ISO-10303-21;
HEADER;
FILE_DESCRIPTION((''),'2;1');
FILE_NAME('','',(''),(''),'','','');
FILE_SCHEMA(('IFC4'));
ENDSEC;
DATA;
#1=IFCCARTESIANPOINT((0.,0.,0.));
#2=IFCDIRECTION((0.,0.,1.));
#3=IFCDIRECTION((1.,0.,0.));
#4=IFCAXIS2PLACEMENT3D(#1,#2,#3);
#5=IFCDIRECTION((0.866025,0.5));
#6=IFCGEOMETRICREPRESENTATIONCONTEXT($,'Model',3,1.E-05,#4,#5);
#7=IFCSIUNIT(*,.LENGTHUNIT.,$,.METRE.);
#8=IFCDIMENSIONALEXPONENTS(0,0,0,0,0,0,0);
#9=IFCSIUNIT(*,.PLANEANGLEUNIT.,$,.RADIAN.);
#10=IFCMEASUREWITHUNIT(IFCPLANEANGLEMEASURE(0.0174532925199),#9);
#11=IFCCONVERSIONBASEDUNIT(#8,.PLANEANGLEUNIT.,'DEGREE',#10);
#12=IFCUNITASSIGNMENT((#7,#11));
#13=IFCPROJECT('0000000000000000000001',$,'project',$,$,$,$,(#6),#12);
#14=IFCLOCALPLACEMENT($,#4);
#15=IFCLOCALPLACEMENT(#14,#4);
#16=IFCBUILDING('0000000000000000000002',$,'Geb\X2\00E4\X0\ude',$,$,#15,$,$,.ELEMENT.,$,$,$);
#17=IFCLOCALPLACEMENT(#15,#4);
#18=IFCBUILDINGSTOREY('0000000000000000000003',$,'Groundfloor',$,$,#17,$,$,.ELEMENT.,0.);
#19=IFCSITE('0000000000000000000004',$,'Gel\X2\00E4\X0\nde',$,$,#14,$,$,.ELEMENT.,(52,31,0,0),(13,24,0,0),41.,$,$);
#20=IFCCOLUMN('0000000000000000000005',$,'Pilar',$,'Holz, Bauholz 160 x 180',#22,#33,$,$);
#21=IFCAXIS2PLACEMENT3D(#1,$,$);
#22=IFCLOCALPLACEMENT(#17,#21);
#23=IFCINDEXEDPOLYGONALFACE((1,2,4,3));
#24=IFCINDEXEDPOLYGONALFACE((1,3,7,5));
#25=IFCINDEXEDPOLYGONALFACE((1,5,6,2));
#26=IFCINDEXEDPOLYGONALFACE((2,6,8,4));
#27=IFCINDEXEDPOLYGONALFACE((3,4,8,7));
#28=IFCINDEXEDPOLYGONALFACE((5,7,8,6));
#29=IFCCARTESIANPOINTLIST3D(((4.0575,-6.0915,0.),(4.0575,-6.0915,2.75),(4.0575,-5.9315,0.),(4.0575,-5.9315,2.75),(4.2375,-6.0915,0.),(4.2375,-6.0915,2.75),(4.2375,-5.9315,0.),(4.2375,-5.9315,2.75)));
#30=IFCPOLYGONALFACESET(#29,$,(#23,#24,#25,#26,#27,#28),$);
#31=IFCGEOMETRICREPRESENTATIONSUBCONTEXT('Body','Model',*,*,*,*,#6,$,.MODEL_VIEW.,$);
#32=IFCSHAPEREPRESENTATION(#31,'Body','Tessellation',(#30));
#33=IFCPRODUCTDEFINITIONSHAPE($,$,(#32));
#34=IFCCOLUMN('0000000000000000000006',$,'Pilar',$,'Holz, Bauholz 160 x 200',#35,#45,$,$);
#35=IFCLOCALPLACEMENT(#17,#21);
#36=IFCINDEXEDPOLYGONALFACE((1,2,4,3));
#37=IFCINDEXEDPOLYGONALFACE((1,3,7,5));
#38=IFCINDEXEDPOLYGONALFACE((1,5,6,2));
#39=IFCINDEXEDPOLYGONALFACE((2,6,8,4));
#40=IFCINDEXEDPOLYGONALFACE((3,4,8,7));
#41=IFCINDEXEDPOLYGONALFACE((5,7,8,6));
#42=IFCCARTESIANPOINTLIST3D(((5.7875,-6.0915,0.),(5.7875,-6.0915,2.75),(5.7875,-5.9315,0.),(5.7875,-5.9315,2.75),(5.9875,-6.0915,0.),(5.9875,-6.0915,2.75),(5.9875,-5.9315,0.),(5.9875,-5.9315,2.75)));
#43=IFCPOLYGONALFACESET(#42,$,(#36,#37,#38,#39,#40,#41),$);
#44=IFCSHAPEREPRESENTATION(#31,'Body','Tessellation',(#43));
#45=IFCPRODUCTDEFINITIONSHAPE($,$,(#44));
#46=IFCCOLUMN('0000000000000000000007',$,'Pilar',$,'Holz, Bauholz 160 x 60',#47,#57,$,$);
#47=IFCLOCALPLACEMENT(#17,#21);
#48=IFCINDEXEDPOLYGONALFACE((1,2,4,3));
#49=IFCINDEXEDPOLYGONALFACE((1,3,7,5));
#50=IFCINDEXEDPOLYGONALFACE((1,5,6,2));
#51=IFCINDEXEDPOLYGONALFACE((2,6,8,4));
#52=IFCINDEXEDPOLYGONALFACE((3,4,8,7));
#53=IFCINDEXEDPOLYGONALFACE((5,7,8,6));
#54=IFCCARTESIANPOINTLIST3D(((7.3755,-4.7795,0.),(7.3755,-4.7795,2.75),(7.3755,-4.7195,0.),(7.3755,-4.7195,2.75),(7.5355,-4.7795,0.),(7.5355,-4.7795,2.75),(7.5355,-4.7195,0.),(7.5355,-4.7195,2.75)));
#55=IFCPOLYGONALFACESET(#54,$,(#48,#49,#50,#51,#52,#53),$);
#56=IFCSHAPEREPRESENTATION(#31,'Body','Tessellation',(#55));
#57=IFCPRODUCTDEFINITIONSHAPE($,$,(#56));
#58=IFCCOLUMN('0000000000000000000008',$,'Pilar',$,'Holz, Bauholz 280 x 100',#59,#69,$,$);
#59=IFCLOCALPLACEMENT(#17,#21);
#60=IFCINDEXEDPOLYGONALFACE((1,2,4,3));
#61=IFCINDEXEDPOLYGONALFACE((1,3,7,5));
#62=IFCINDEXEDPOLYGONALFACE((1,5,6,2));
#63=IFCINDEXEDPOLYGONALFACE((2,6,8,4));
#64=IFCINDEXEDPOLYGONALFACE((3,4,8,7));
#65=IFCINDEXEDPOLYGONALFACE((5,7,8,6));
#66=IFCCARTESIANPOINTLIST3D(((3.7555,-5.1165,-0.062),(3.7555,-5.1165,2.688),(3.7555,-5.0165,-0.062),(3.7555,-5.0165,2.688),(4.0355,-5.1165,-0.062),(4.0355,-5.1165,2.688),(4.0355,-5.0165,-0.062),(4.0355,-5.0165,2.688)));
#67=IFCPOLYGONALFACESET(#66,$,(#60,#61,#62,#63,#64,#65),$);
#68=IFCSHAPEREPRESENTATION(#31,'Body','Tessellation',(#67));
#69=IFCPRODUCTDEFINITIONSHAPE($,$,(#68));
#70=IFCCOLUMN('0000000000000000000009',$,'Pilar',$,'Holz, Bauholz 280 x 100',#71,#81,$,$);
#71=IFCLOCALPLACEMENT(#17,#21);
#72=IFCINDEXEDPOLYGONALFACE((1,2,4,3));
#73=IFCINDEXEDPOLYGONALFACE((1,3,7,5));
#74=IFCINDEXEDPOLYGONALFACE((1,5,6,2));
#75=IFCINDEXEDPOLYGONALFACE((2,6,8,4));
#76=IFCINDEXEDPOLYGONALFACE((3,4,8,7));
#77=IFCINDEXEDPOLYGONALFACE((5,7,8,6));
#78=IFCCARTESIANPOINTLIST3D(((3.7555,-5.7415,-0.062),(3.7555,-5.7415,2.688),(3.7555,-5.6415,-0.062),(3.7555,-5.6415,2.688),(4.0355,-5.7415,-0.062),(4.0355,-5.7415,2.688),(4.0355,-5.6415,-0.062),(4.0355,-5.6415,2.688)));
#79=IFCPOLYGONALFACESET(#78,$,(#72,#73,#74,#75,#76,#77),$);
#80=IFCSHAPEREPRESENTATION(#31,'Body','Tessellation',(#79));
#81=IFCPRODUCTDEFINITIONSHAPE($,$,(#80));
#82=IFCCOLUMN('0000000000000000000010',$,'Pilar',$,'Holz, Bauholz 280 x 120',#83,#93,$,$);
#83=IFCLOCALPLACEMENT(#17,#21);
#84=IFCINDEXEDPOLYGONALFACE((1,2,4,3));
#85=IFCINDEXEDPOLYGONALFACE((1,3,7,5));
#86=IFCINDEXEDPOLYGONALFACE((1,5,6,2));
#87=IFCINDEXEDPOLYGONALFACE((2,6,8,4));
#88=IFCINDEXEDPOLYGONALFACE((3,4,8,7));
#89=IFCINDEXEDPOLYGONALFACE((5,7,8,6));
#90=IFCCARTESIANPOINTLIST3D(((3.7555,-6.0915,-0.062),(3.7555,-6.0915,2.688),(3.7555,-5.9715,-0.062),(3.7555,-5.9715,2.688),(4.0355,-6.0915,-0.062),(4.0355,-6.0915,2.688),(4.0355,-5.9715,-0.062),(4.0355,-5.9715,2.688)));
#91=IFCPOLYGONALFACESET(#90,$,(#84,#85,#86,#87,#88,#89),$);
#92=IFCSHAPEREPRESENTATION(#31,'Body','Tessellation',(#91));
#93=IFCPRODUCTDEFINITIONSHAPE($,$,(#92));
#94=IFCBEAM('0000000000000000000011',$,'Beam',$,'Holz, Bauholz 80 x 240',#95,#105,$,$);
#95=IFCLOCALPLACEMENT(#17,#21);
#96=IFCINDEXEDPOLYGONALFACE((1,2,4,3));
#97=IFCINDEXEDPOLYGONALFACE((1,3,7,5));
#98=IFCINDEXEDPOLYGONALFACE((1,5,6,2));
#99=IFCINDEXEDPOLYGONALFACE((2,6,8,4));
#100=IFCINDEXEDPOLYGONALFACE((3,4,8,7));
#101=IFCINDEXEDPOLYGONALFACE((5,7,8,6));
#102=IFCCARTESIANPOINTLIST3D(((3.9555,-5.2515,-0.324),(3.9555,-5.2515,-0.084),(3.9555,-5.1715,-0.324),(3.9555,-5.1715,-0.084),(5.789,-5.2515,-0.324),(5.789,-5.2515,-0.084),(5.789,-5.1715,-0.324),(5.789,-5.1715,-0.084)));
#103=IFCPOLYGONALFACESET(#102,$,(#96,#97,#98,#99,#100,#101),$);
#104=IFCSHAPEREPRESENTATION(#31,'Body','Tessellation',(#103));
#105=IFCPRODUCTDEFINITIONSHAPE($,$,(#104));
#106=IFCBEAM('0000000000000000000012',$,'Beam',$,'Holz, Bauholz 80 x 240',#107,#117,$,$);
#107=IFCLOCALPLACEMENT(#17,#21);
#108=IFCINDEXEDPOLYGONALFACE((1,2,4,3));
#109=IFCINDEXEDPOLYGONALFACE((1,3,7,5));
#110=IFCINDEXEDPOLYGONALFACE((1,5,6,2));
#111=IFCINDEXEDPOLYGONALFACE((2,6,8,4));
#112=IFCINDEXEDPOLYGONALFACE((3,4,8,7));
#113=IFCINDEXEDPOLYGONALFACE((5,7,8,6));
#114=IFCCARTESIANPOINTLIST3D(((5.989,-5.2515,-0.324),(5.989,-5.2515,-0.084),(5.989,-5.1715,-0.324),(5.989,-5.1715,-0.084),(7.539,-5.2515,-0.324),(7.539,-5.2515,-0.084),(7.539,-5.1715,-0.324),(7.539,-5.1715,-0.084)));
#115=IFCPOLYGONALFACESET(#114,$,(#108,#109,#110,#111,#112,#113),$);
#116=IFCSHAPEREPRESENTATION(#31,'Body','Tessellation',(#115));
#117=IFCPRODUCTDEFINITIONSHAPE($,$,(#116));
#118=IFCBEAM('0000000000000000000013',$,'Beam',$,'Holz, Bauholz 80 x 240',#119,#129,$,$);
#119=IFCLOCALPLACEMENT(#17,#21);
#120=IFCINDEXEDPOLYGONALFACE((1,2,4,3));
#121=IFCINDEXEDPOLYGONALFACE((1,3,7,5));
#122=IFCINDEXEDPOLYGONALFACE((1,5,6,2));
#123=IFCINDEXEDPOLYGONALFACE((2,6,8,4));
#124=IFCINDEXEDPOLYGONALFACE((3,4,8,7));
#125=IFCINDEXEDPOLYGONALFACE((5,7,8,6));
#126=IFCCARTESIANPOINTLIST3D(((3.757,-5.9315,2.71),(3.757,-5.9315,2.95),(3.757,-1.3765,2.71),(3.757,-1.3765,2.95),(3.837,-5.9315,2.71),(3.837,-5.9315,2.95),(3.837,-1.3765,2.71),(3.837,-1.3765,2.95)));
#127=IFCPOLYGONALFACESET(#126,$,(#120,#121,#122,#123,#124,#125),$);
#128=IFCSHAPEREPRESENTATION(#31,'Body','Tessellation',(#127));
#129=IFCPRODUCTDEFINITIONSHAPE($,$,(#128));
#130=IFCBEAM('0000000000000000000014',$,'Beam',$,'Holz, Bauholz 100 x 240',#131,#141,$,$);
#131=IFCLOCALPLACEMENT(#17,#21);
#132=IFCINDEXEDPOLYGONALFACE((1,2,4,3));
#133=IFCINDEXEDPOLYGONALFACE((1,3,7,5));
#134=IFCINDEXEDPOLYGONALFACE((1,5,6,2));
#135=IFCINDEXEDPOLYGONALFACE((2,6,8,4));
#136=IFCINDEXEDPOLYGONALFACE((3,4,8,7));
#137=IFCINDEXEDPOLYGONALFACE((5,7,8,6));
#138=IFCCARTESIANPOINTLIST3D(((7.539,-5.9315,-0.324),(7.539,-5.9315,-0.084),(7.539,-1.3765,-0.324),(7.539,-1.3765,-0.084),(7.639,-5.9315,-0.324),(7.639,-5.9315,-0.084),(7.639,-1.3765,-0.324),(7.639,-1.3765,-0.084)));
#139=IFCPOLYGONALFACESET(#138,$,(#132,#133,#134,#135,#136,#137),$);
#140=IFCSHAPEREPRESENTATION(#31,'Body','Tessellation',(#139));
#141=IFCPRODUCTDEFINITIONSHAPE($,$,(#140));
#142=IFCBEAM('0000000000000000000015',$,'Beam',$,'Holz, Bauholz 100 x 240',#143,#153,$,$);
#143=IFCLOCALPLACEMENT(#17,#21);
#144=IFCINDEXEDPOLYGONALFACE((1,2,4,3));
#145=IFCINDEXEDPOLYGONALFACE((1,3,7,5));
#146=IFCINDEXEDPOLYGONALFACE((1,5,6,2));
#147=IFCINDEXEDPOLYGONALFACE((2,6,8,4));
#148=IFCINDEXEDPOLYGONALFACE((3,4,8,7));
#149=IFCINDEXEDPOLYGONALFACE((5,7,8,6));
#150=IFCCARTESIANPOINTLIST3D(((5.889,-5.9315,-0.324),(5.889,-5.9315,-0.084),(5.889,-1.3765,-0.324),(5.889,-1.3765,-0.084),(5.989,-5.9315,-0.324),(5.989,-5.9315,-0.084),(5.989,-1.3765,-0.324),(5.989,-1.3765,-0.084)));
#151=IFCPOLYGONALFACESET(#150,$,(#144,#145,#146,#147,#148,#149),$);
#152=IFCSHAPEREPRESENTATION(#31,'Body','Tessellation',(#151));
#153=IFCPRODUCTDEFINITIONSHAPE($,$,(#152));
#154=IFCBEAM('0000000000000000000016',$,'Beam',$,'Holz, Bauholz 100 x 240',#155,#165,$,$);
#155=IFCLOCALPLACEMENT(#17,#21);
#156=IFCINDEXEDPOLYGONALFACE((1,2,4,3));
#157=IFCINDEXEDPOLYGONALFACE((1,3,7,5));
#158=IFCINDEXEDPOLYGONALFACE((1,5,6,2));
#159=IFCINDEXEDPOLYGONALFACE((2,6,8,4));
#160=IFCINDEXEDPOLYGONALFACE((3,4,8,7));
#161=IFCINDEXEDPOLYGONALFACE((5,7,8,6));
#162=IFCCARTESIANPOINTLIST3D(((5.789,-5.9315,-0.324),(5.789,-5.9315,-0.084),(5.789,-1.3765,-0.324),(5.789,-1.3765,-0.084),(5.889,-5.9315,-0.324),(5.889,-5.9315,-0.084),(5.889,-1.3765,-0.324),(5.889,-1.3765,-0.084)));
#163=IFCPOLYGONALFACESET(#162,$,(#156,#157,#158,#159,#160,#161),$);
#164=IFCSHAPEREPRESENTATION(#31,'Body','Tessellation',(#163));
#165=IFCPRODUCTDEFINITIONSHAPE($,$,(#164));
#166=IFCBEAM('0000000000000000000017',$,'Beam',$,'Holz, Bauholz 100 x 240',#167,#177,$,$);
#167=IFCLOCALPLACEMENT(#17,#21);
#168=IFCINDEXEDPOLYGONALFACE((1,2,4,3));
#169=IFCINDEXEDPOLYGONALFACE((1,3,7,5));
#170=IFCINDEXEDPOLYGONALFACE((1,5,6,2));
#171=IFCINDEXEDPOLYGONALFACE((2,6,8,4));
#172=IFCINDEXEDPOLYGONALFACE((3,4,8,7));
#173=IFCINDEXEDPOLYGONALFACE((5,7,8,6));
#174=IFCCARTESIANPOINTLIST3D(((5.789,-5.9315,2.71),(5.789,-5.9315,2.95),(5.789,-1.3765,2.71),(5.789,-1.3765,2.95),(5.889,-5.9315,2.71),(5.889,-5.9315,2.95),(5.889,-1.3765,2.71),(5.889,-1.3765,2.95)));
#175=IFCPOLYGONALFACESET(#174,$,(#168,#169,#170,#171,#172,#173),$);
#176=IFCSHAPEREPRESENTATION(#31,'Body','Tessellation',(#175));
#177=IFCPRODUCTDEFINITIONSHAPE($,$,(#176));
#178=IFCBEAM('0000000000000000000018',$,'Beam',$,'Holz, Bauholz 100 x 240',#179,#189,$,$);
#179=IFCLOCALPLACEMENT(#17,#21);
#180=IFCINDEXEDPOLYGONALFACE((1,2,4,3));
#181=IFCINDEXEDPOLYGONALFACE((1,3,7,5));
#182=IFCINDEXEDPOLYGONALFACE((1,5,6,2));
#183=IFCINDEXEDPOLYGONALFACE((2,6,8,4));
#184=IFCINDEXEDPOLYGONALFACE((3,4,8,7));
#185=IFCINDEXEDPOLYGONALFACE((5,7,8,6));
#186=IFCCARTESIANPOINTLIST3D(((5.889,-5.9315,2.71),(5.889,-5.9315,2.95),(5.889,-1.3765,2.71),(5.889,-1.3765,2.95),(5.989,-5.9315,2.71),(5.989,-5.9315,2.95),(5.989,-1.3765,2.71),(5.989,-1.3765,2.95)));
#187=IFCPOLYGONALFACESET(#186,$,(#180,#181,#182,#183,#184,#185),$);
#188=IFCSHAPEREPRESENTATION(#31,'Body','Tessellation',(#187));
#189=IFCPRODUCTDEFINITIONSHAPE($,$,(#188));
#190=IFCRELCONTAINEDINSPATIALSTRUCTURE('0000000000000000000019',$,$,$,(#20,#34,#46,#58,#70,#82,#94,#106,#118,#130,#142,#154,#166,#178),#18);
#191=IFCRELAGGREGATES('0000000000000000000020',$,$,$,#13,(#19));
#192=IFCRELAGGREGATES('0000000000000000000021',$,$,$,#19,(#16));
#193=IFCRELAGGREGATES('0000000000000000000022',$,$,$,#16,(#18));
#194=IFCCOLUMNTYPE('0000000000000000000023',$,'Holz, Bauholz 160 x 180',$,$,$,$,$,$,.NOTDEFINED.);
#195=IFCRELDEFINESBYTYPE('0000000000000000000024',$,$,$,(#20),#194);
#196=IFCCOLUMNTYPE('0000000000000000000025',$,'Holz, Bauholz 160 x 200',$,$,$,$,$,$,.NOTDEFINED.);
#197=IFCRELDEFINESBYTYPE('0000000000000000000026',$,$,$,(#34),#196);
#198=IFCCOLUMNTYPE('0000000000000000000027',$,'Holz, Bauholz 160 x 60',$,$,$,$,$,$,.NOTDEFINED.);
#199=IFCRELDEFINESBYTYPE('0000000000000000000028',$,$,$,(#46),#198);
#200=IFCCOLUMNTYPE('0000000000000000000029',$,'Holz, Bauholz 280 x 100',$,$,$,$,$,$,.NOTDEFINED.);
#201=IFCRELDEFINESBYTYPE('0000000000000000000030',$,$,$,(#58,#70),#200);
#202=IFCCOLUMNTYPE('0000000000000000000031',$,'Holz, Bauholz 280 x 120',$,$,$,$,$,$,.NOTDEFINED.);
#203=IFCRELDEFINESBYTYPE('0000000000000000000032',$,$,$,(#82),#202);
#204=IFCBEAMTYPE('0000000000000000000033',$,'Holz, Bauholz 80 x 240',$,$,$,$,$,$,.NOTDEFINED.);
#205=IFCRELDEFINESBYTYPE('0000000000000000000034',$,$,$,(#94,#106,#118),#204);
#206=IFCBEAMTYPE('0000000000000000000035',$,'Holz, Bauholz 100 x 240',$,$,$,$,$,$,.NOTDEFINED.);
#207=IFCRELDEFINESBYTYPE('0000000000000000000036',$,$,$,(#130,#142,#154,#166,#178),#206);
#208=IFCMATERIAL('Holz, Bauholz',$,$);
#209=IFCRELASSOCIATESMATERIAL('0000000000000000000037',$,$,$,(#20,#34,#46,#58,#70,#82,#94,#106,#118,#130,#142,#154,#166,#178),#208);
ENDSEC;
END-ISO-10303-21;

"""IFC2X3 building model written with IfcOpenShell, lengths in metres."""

from ifc_helpers import new_model, entity, si_unit, converted_unit, direction, frame, frame_2d, origin_with_axes, origin_2d_with_axis, place, context, subcontext, project, spatial, rectangle, extrude, clip, halfspace, material, type_object, element, save


model = new_model("IFC2X3")

# Units and contexts
model_context = context("Model", 3, precision=1e-05, world=origin_with_axes(), true_north=direction((0.866025, 0.5)))
body_context = subcontext(model_context, "Body", "Model", "MODEL_VIEW")
ifc_project = project(units=[si_unit("LENGTHUNIT", "METRE"), converted_unit("PLANEANGLEUNIT", "DEGREE", entity("IfcPlaneAngleMeasure", 0.0174532925199), si_unit("PLANEANGLEUNIT", "RADIAN"), dimensions=[0, 0, 0, 0, 0, 0, 0])], contexts=[model_context])

# Site, building, storey
site_placement = place(None, origin_with_axes())
site = spatial("IfcSite", under=ifc_project, at=site_placement, Name="Gelände", CompositionType="ELEMENT", RefLatitude=(52, 31, 0, 0), RefLongitude=(13, 24, 0, 0), RefElevation=41.0)
building_placement = place(site_placement, origin_with_axes())
building = spatial("IfcBuilding", under=site, at=building_placement, Name="Gebäude", CompositionType="ELEMENT")
storey_placement = place(building_placement, origin_with_axes())
storey = spatial("IfcBuildingStorey", under=building, at=storey_placement, Name="Groundfloor", CompositionType="ELEMENT", Elevation=0.0)

# Columns
ifc_material_1 = material(Name="Holz, Bauholz")
column_type_1 = type_object("IfcColumnType", Name="Holz, Bauholz 160 x 180", PredefinedType="NOTDEFINED")
column_1_placement = place(storey_placement, frame((4.1475, -6.0115, 0.0), z_axis=(0.0, 0.0, 1.0), x_axis=(1.0, 0.0, 0.0)))
element("IfcColumn", 1, at=column_1_placement, inside=storey, type_object=column_type_1, material=ifc_material_1, Name="Pilar", ObjectType="Holz, Bauholz 160 x 180", context=body_context, shape_type="Clipping", body=[
    clip(clip(extrude(rectangle(XDim=0.16, YDim=0.18, at=origin_2d_with_axis()), frame((0.0, 0.0, 0.0), z_axis=(0.0, 0.0, 1.0), x_axis=(0.0, 1.0, 0.0)), (0.0, 0.0, 1.0), 2.75), halfspace(frame((0.0, 0.0, 2.75), z_axis=(0.0, 0.0, -1.0), x_axis=(0.0, 1.0, 0.0)), True)), halfspace(frame((0.0, 0.0, 0.0), z_axis=(0.0, 0.0, 1.0), x_axis=(0.0, -1.0, 0.0)), True)),
])
column_type_2 = type_object("IfcColumnType", Name="Holz, Bauholz 160 x 200", PredefinedType="NOTDEFINED")
column_2_placement = place(storey_placement, frame((5.8875, -6.0115, 0.0), z_axis=(0.0, 0.0, 1.0), x_axis=(1.0, 0.0, 0.0)))
element("IfcColumn", 2, at=column_2_placement, inside=storey, type_object=column_type_2, material=ifc_material_1, Name="Pilar", ObjectType="Holz, Bauholz 160 x 200", context=body_context, shape_type="Clipping", body=[
    clip(clip(extrude(rectangle(XDim=0.16, YDim=0.2, at=origin_2d_with_axis()), frame((0.0, 0.0, 0.0), z_axis=(0.0, 0.0, 1.0), x_axis=(0.0, 1.0, 0.0)), (0.0, 0.0, 1.0), 2.75), halfspace(frame((0.0, 0.0, 2.75), z_axis=(0.0, 0.0, -1.0), x_axis=(0.0, 1.0, 0.0)), True)), halfspace(frame((0.0, 0.0, 0.0), z_axis=(0.0, 0.0, 1.0), x_axis=(0.0, -1.0, 0.0)), True)),
])
column_type_3 = type_object("IfcColumnType", Name="Holz, Bauholz 160 x 60", PredefinedType="NOTDEFINED")
column_3_placement = place(storey_placement, frame((7.4555, -4.7495, 0.0), z_axis=(0.0, 0.0, 1.0), x_axis=(0.0, -1.0, 0.0)))
element("IfcColumn", 3, at=column_3_placement, inside=storey, type_object=column_type_3, material=ifc_material_1, Name="Pilar", ObjectType="Holz, Bauholz 160 x 60", context=body_context, shape_type="Clipping", body=[
    clip(clip(extrude(rectangle(XDim=0.16, YDim=0.06, at=origin_2d_with_axis()), frame((0.0, 0.0, 0.0), z_axis=(0.0, 0.0, 1.0), x_axis=(0.0, 1.0, 0.0)), (0.0, 0.0, 1.0), 2.75), halfspace(frame((0.0, 0.0, 2.75), z_axis=(0.0, 0.0, -1.0), x_axis=(0.0, 1.0, 0.0)), True)), halfspace(frame((0.0, 0.0, 0.0), z_axis=(0.0, 0.0, 1.0), x_axis=(0.0, -1.0, 0.0)), True)),
])
column_type_4 = type_object("IfcColumnType", Name="Holz, Bauholz 280 x 100", PredefinedType="NOTDEFINED")
for number, where, z_axis, x_axis, name in (
    (4, (3.8955, -5.0665, -0.062), (0.0, 0.0, 1.0), (0.0, 1.0, 0.0), "Pilar"),
    (5, (3.8955, -5.6915, -0.062), (0.0, 0.0, 1.0), (0.0, 1.0, 0.0), "Pilar"),
):
    element("IfcColumn", number, at=place(storey_placement, frame(where, z_axis=z_axis, x_axis=x_axis)), inside=storey, type_object=column_type_4, material=ifc_material_1, Name=name, ObjectType="Holz, Bauholz 280 x 100", context=body_context, shape_type="Clipping", body=[
        clip(clip(extrude(rectangle(XDim=0.28, YDim=0.1, at=origin_2d_with_axis()), frame((0.0, 0.0, 0.0), z_axis=(0.0, 0.0, 1.0), x_axis=(0.0, 1.0, 0.0)), (0.0, 0.0, 1.0), 2.75), halfspace(frame((0.0, 0.0, 2.75), z_axis=(0.0, 0.0, -1.0), x_axis=(0.0, 1.0, 0.0)), True)), halfspace(frame((0.0, 0.0, 0.0), z_axis=(0.0, 0.0, 1.0), x_axis=(0.0, -1.0, 0.0)), True)),
    ])
column_type_5 = type_object("IfcColumnType", Name="Holz, Bauholz 280 x 120", PredefinedType="NOTDEFINED")
column_4_placement = place(storey_placement, frame((3.8955, -6.0315, -0.062), z_axis=(0.0, 0.0, 1.0), x_axis=(0.0, 1.0, 0.0)))
element("IfcColumn", 6, at=column_4_placement, inside=storey, type_object=column_type_5, material=ifc_material_1, Name="Pilar", ObjectType="Holz, Bauholz 280 x 120", context=body_context, shape_type="Clipping", body=[
    clip(clip(extrude(rectangle(XDim=0.28, YDim=0.12, at=origin_2d_with_axis()), frame((0.0, 0.0, 0.0), z_axis=(0.0, 0.0, 1.0), x_axis=(0.0, 1.0, 0.0)), (0.0, 0.0, 1.0), 2.75), halfspace(frame((0.0, 0.0, 2.75), z_axis=(0.0, 0.0, -1.0), x_axis=(0.0, 1.0, 0.0)), True)), halfspace(frame((0.0, 0.0, 0.0), z_axis=(0.0, 0.0, 1.0), x_axis=(0.0, -1.0, 0.0)), True)),
])

# Beams
beam_type_1 = type_object("IfcBeamType", Name="Holz, Bauholz 80 x 240", PredefinedType="NOTDEFINED")
beam_1_placement = place(storey_placement, frame((5.789, -5.2115, -0.084), z_axis=(0.0, 0.0, 1.0), x_axis=(0.0, 1.0, 0.0)))
element("IfcBeam", 7, at=beam_1_placement, inside=storey, type_object=beam_type_1, material=ifc_material_1, Name="Beam", ObjectType="Holz, Bauholz 80 x 240", context=body_context, shape_type="SweptSolid", body=[
    extrude(rectangle(XDim=0.24, YDim=0.08, at=frame_2d((-0.12, 0.0), x_axis=(1.0, 0.0))), frame((0.0, 0.0, 0.0), z_axis=(0.0, 1.0, 0.0), x_axis=(0.0, 0.0, 1.0)), (0.0, 0.0, 1.0), 1.8335),
])
beam_2_placement = place(storey_placement, frame((7.539, -5.2115, -0.084), z_axis=(0.0, 0.0, 1.0), x_axis=(0.0, 1.0, 0.0)))
element("IfcBeam", 8, at=beam_2_placement, inside=storey, type_object=beam_type_1, material=ifc_material_1, Name="Beam", ObjectType="Holz, Bauholz 80 x 240", context=body_context, shape_type="SweptSolid", body=[
    extrude(rectangle(XDim=0.24, YDim=0.08, at=frame_2d((-0.12, 0.0), x_axis=(1.0, 0.0))), frame((0.0, 0.0, 0.0), z_axis=(0.0, 1.0, 0.0), x_axis=(0.0, 0.0, 1.0)), (0.0, 0.0, 1.0), 1.55),
])
beam_3_placement = place(storey_placement, frame((3.797, -5.9315, 2.95), z_axis=(0.0, 0.0, 1.0), x_axis=(1.0, 0.0, 0.0)))
element("IfcBeam", 9, at=beam_3_placement, inside=storey, type_object=beam_type_1, material=ifc_material_1, Name="Beam", ObjectType="Holz, Bauholz 80 x 240", context=body_context, shape_type="SweptSolid", body=[
    extrude(rectangle(XDim=0.24, YDim=0.08, at=frame_2d((-0.12, 0.0), x_axis=(1.0, 0.0))), frame((0.0, 0.0, 0.0), z_axis=(0.0, 1.0, 0.0), x_axis=(0.0, 0.0, 1.0)), (0.0, 0.0, 1.0), 4.555),
])
beam_type_2 = type_object("IfcBeamType", Name="Holz, Bauholz 100 x 240", PredefinedType="NOTDEFINED")
for number, where, z_axis, x_axis, name in (
    (10, (7.589, -5.9315, -0.084), (0.0, 0.0, 1.0), (1.0, 0.0, 0.0), "Beam"),
    (11, (5.939, -5.9315, -0.084), (0.0, 0.0, 1.0), (1.0, 0.0, 0.0), "Beam"),
    (12, (5.839, -5.9315, -0.084), (0.0, 0.0, 1.0), (1.0, 0.0, 0.0), "Beam"),
):
    element("IfcBeam", number, at=place(storey_placement, frame(where, z_axis=z_axis, x_axis=x_axis)), inside=storey, type_object=beam_type_2, material=ifc_material_1, Name=name, ObjectType="Holz, Bauholz 100 x 240", context=body_context, shape_type="SweptSolid", body=[
        extrude(rectangle(XDim=0.24, YDim=0.1, at=frame_2d((-0.12, 0.0), x_axis=(1.0, 0.0))), frame((0.0, 0.0, 0.0), z_axis=(0.0, 1.0, 0.0), x_axis=(0.0, 0.0, 1.0)), (0.0, 0.0, 1.0), 4.555),
    ])
for number, where, z_axis, x_axis, name in (
    (13, (5.839, -5.9315, 2.95), (0.0, 0.0, 1.0), (1.0, 0.0, 0.0), "Beam"),
    (14, (5.939, -5.9315, 2.95), (0.0, 0.0, 1.0), (1.0, 0.0, 0.0), "Beam"),
):
    element("IfcBeam", number, at=place(storey_placement, frame(where, z_axis=z_axis, x_axis=x_axis)), inside=storey, type_object=beam_type_2, material=ifc_material_1, Name=name, ObjectType="Holz, Bauholz 100 x 240", context=body_context, shape_type="SweptSolid", body=[
        extrude(rectangle(XDim=0.24, YDim=0.1, at=frame_2d((-0.12, 0.0), x_axis=(1.0, 0.0))), frame((0.0, 0.0, 0.0), z_axis=(0.0, 1.0, 0.0), x_axis=(0.0, 0.0, 1.0)), (0.0, 0.0, 1.0), 4.555),
    ])

save(model, "model.ifc")
